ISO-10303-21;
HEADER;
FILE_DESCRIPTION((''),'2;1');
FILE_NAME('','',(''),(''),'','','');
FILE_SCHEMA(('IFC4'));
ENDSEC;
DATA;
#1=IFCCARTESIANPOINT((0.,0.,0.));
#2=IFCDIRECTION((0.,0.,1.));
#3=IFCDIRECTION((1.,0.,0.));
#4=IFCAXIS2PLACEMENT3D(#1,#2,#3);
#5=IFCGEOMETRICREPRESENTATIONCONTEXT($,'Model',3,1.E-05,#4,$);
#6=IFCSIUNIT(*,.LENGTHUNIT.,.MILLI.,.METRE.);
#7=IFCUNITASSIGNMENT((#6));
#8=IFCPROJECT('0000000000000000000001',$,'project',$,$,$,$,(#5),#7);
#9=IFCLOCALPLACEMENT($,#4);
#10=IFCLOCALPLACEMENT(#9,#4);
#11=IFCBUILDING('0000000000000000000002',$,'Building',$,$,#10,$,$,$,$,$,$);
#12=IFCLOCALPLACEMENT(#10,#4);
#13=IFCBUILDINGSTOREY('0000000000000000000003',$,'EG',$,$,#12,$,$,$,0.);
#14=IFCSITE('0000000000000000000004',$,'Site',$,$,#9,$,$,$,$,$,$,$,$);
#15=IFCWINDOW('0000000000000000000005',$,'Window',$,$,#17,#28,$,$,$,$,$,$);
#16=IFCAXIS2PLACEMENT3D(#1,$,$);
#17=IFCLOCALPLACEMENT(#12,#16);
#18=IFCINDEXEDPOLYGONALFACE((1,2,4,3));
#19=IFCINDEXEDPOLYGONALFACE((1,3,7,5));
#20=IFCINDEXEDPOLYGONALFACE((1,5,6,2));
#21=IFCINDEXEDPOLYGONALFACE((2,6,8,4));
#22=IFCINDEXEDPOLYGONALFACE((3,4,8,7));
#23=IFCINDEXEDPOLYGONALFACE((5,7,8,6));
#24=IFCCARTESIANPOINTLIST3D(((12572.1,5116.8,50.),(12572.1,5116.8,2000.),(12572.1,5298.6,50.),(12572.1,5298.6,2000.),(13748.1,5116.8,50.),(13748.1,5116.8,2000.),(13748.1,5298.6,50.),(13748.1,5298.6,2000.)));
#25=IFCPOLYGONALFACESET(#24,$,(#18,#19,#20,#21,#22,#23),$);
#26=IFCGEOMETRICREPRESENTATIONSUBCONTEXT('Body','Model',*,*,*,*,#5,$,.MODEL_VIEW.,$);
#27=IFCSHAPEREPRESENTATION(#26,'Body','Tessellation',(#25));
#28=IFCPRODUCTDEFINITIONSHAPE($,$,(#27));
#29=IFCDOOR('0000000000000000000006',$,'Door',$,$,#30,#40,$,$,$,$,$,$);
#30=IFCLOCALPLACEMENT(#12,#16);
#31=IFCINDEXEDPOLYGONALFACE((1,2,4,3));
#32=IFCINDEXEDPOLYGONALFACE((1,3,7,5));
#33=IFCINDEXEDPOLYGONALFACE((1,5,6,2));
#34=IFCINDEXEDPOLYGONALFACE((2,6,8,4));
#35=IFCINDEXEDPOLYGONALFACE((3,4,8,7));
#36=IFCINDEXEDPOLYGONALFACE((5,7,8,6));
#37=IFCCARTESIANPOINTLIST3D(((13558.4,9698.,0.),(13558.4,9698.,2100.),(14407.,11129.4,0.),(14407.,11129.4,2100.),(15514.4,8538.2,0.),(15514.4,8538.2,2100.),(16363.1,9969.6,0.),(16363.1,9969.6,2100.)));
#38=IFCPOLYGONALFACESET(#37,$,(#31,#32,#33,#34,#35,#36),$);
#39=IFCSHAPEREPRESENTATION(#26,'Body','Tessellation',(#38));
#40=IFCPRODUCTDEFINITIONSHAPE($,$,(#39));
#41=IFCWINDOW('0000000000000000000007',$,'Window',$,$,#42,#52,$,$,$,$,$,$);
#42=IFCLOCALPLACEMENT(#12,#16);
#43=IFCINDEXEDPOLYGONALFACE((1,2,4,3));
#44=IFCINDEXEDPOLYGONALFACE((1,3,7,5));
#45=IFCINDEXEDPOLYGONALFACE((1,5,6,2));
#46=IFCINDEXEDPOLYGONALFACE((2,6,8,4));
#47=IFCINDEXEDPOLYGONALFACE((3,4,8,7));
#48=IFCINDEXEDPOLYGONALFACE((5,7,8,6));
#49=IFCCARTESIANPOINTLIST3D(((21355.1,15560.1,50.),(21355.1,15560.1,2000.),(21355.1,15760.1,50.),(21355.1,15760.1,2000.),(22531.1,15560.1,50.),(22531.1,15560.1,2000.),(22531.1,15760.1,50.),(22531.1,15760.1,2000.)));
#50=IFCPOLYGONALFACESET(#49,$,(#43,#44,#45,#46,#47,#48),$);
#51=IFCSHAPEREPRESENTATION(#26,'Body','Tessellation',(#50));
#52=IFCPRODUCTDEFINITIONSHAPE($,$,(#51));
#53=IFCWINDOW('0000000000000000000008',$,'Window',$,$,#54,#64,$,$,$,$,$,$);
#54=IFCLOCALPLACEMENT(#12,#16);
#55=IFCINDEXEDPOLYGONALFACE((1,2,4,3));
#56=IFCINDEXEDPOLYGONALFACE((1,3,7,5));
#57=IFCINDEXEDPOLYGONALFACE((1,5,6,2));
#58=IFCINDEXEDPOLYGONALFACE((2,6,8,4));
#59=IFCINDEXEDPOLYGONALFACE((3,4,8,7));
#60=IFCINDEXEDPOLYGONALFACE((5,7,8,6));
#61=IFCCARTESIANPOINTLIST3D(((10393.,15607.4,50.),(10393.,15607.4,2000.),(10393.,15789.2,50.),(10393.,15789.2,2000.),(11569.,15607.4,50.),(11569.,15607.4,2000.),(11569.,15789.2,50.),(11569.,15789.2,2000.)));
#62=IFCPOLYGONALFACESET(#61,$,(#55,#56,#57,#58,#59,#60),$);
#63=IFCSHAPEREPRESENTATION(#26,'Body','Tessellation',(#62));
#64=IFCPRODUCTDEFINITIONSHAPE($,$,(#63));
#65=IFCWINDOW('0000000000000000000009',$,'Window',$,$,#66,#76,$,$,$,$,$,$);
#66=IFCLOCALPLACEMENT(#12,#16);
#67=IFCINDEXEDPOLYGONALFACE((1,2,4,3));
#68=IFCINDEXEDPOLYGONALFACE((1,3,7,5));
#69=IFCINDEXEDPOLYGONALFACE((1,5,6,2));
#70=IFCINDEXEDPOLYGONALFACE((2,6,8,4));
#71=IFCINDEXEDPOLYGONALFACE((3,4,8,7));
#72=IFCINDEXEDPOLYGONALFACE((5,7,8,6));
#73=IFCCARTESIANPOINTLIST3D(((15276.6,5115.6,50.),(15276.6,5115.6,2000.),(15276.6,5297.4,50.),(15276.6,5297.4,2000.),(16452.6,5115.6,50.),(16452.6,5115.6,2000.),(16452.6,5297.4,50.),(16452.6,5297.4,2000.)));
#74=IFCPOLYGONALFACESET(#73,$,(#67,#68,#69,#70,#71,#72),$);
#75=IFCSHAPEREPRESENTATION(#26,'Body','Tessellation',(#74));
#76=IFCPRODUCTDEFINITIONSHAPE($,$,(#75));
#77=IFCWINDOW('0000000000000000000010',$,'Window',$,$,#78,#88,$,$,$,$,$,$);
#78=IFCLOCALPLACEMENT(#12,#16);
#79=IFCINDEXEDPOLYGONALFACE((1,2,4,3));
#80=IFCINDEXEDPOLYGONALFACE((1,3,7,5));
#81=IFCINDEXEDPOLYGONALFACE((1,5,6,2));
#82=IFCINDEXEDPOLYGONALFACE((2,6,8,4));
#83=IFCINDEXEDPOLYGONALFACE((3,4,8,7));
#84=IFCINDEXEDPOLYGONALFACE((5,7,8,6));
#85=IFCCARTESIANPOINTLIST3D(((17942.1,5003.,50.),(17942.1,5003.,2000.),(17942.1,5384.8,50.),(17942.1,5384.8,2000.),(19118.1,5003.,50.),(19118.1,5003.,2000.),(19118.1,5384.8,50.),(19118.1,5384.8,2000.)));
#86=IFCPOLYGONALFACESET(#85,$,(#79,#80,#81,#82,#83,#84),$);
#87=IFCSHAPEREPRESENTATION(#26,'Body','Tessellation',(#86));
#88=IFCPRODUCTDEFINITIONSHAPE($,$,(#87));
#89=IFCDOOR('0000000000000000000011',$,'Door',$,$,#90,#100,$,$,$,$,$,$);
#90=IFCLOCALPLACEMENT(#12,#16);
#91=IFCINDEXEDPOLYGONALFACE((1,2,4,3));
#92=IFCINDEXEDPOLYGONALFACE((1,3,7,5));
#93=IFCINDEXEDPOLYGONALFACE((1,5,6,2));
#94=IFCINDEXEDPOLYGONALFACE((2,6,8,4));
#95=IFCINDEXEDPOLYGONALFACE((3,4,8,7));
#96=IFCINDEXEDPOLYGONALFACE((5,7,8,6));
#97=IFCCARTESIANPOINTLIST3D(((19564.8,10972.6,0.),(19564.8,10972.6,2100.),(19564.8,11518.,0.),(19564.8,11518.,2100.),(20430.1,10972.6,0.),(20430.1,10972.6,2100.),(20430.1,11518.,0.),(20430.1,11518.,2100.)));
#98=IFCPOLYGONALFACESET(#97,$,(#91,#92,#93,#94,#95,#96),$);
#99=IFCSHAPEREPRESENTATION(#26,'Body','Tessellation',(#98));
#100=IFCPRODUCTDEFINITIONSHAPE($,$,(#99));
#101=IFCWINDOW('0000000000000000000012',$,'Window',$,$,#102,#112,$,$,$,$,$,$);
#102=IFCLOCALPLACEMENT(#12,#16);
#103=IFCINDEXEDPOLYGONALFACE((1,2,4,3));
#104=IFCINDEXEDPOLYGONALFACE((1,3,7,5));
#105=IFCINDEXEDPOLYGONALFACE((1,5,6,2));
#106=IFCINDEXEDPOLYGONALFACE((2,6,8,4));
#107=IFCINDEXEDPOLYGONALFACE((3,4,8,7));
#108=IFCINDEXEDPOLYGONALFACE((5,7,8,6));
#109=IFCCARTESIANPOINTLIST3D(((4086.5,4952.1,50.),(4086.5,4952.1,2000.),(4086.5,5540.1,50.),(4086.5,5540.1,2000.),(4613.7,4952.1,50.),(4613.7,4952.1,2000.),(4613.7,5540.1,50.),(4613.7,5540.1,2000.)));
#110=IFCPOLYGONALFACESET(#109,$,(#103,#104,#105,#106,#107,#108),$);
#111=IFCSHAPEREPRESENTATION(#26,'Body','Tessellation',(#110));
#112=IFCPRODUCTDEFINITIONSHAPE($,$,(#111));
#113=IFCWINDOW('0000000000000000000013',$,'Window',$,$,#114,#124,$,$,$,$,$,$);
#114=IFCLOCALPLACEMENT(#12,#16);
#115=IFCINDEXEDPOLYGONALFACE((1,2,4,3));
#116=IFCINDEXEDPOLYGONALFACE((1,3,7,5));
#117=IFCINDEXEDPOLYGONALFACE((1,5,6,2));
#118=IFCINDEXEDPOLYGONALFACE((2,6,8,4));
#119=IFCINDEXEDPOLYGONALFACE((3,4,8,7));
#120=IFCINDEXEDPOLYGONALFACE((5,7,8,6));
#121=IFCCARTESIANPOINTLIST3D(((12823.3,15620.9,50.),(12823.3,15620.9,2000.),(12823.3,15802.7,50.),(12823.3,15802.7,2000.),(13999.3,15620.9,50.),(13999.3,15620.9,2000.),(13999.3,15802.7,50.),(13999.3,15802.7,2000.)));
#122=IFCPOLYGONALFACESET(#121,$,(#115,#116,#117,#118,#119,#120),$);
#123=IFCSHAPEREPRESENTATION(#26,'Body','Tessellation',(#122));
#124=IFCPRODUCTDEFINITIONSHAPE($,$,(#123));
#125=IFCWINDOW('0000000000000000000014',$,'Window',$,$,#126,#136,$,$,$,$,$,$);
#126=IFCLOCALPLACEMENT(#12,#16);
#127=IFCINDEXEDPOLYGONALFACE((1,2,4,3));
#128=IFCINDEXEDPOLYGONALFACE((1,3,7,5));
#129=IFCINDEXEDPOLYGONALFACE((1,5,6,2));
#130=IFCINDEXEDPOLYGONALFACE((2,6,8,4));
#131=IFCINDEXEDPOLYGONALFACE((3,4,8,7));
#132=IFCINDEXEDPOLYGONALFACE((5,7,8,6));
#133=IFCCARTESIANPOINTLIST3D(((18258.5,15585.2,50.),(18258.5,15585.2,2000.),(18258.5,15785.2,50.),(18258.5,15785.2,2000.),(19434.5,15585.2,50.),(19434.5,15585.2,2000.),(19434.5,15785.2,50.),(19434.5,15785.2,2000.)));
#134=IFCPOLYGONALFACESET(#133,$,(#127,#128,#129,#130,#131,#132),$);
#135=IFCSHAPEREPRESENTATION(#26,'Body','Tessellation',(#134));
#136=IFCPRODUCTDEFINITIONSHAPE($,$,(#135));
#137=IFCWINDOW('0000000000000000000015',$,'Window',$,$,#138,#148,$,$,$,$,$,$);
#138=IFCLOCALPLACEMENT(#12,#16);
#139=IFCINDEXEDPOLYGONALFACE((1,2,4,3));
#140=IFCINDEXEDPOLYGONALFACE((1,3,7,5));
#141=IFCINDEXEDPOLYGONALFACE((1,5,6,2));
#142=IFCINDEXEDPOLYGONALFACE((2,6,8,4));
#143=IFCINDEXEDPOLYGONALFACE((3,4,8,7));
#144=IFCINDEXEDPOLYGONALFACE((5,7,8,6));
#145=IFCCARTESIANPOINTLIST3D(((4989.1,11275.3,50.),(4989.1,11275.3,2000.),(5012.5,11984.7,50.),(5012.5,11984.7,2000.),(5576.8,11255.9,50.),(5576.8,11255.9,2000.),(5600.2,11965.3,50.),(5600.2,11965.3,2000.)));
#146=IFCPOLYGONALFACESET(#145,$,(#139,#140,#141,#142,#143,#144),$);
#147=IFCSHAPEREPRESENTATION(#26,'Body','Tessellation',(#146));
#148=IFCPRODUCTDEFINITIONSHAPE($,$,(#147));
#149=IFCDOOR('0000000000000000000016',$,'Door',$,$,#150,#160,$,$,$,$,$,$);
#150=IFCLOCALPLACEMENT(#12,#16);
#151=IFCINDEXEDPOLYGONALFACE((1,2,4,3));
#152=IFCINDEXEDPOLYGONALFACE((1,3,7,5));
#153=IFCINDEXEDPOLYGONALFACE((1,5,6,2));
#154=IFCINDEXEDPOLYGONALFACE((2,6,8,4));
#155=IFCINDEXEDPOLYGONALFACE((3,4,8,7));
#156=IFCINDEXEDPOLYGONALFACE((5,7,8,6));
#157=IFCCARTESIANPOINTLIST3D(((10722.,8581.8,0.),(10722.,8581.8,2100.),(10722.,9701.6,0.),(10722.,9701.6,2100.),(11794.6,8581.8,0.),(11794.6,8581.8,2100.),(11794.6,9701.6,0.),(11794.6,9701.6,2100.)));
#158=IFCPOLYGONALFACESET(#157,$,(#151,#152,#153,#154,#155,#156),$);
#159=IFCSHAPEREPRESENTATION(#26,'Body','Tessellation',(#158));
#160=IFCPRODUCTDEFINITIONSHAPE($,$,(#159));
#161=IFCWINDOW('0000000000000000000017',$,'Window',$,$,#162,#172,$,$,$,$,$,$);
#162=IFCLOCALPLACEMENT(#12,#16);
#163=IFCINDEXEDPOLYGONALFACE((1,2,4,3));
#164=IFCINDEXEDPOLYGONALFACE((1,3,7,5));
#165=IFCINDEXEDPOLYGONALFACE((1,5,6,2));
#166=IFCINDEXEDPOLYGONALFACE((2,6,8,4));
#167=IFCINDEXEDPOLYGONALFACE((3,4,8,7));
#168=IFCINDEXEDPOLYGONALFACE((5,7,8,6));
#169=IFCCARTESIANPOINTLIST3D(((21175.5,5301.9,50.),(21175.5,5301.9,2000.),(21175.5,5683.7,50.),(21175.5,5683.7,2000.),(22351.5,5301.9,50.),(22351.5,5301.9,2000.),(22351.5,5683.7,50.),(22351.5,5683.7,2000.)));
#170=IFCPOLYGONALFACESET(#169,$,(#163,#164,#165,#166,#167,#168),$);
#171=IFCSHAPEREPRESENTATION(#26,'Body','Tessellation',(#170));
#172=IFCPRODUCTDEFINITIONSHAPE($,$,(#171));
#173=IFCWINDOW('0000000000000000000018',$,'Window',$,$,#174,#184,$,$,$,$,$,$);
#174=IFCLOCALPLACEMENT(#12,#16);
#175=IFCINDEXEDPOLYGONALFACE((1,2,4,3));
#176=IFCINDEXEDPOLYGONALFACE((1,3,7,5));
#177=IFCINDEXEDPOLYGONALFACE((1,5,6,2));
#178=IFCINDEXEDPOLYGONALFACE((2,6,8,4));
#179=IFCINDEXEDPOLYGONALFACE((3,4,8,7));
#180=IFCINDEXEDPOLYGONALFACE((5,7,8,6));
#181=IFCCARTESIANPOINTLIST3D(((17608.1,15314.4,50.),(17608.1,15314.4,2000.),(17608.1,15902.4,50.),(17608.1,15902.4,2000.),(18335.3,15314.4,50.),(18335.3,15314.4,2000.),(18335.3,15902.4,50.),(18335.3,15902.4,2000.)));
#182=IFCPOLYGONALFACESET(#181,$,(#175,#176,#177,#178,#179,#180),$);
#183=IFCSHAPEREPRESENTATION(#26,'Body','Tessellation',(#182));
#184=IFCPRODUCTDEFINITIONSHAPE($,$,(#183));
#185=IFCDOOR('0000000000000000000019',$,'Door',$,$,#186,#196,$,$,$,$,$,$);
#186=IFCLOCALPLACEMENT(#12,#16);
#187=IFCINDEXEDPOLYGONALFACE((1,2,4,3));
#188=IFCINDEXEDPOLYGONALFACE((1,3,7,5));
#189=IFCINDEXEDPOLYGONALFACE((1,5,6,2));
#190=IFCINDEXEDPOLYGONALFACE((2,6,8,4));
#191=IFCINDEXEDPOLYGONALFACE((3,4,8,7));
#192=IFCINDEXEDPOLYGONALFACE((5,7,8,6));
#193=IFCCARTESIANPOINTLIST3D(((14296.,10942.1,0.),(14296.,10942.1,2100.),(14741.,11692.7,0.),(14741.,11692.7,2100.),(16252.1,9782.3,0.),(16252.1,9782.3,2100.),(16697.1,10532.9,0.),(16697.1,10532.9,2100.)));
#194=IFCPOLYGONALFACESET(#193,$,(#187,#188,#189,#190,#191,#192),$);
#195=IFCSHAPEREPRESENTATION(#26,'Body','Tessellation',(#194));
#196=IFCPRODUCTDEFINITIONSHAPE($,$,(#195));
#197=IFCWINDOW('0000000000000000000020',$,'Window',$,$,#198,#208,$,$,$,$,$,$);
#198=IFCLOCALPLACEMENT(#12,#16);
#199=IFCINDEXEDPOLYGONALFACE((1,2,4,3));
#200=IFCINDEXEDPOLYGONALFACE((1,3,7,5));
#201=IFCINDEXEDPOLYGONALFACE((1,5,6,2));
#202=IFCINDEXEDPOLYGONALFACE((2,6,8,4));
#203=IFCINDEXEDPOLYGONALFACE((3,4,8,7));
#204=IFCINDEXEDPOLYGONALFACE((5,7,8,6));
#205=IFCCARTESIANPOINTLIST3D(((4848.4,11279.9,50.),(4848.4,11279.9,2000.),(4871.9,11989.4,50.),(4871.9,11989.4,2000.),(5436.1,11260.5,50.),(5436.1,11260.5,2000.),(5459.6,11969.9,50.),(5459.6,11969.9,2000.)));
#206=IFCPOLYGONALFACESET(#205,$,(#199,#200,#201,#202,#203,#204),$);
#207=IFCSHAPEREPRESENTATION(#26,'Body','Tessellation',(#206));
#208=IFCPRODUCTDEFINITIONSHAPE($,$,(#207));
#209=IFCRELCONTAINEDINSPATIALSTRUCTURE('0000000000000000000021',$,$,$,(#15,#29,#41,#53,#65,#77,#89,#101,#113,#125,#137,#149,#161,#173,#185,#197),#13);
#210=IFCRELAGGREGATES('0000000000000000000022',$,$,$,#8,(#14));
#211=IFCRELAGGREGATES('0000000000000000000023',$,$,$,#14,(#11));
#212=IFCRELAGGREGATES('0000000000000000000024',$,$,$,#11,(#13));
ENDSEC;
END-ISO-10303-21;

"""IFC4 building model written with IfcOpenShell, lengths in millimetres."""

from ifc_helpers import new_model, si_unit, frame, origin_with_axes, place, context, subcontext, project, spatial, rectangle, extrude, element, save


model = new_model("IFC4")

# Units and contexts
model_context = context("Model", 3, precision=1e-05, world=origin_with_axes())
body_context = subcontext(model_context, "Body", "Model", "MODEL_VIEW")
ifc_project = project(units=[si_unit("LENGTHUNIT", "METRE", prefix="MILLI")], contexts=[model_context])

# Site, building, storey
site_placement = place(None, origin_with_axes())
site = spatial("IfcSite", under=ifc_project, at=site_placement, Name="Site")
building_placement = place(site_placement, origin_with_axes())
building = spatial("IfcBuilding", under=site, at=building_placement, Name="Building")
storey_placement = place(building_placement, origin_with_axes())
storey = spatial("IfcBuildingStorey", under=building, at=storey_placement, Name="EG", Elevation=0.0)

# Window
window_1_placement = place(storey_placement, origin_with_axes())
element("IfcWindow", 1, at=window_1_placement, inside=storey, Name="Window", context=body_context, shape_type="SweptSolid", body=[
    extrude(rectangle(XDim=1176.0, YDim=181.8), frame((13160.1, 5207.7, 50.0), z_axis=(0.0, 0.0, 1.0), x_axis=(1.0, 0.0, 0.0)), (0.0, 0.0, 1.0), 1950.0),
])

# Door
door_1_placement = place(storey_placement, origin_with_axes())
element("IfcDoor", 2, at=door_1_placement, inside=storey, Name="Door", context=body_context, shape_type="SweptSolid", body=[
    extrude(rectangle(XDim=1664.0, YDim=2274.1), frame((14960.7, 9833.8, 0.0), z_axis=(0.0, 0.0, 1.0), x_axis=(-0.510011, -0.860168, 0.0)), (0.0, 0.0, 1.0), 2100.0),
])

# Windows
window_2_placement = place(storey_placement, origin_with_axes())
element("IfcWindow", 3, at=window_2_placement, inside=storey, Name="Window", context=body_context, shape_type="SweptSolid", body=[
    extrude(rectangle(XDim=1176.0, YDim=200.0), frame((21943.1, 15660.1, 50.0), z_axis=(0.0, 0.0, 1.0), x_axis=(1.0, 0.0, 0.0)), (0.0, 0.0, 1.0), 1950.0),
])
window_3_placement = place(storey_placement, origin_with_axes())
element("IfcWindow", 4, at=window_3_placement, inside=storey, Name="Window", context=body_context, shape_type="SweptSolid", body=[
    extrude(rectangle(XDim=1176.0, YDim=181.8), frame((10981.0, 15698.3, 50.0), z_axis=(0.0, 0.0, 1.0), x_axis=(1.0, 0.0, 0.0)), (0.0, 0.0, 1.0), 1950.0),
])
window_4_placement = place(storey_placement, origin_with_axes())
element("IfcWindow", 5, at=window_4_placement, inside=storey, Name="Window", context=body_context, shape_type="SweptSolid", body=[
    extrude(rectangle(XDim=1176.0, YDim=181.8), frame((15864.6, 5206.5, 50.0), z_axis=(0.0, 0.0, 1.0), x_axis=(1.0, 0.0, 0.0)), (0.0, 0.0, 1.0), 1950.0),
])
window_5_placement = place(storey_placement, origin_with_axes())
element("IfcWindow", 6, at=window_5_placement, inside=storey, Name="Window", context=body_context, shape_type="SweptSolid", body=[
    extrude(rectangle(XDim=1176.0, YDim=381.8), frame((18530.1, 5193.9, 50.0), z_axis=(0.0, 0.0, 1.0), x_axis=(1.0, 0.0, 0.0)), (0.0, 0.0, 1.0), 1950.0),
])

# Door
door_2_placement = place(storey_placement, origin_with_axes())
element("IfcDoor", 7, at=door_2_placement, inside=storey, Name="Door", context=body_context, shape_type="SweptSolid", body=[
    extrude(rectangle(XDim=865.3, YDim=545.4), frame((19997.4, 11245.3, 0.0), z_axis=(0.0, 0.0, 1.0), x_axis=(1.0, 0.0, 0.0)), (0.0, 0.0, 1.0), 2100.0),
])

# Windows
window_6_placement = place(storey_placement, origin_with_axes())
element("IfcWindow", 8, at=window_6_placement, inside=storey, Name="Window", context=body_context, shape_type="SweptSolid", body=[
    extrude(rectangle(XDim=588.0, YDim=527.2), frame((4350.1, 5246.1, 50.0), z_axis=(0.0, 0.0, 1.0), x_axis=(0.0, 1.0, 0.0)), (0.0, 0.0, 1.0), 1950.0),
])
window_7_placement = place(storey_placement, origin_with_axes())
element("IfcWindow", 9, at=window_7_placement, inside=storey, Name="Window", context=body_context, shape_type="SweptSolid", body=[
    extrude(rectangle(XDim=1176.0, YDim=181.8), frame((13411.3, 15711.8, 50.0), z_axis=(0.0, 0.0, 1.0), x_axis=(1.0, 0.0, 0.0)), (0.0, 0.0, 1.0), 1950.0),
])
window_8_placement = place(storey_placement, origin_with_axes())
element("IfcWindow", 10, at=window_8_placement, inside=storey, Name="Window", context=body_context, shape_type="SweptSolid", body=[
    extrude(rectangle(XDim=1176.0, YDim=200.0), frame((18846.5, 15685.2, 50.0), z_axis=(0.0, 0.0, 1.0), x_axis=(1.0, 0.0, 0.0)), (0.0, 0.0, 1.0), 1950.0),
])
window_9_placement = place(storey_placement, origin_with_axes())
element("IfcWindow", 11, at=window_9_placement, inside=storey, Name="Window", context=body_context, shape_type="SweptSolid", body=[
    extrude(rectangle(XDim=588.0, YDim=709.8), frame((5294.6, 11620.3, 50.0), z_axis=(0.0, 0.0, 1.0), x_axis=(0.999454, -0.03304, 0.0)), (0.0, 0.0, 1.0), 1950.0),
])

# Door
door_3_placement = place(storey_placement, origin_with_axes())
element("IfcDoor", 12, at=door_3_placement, inside=storey, Name="Door", context=body_context, shape_type="SweptSolid", body=[
    extrude(rectangle(XDim=1119.9, YDim=1072.6), frame((11258.3, 9141.7, 0.0), z_axis=(0.0, 0.0, 1.0), x_axis=(0.0, 1.0, 0.0)), (0.0, 0.0, 1.0), 2100.0),
])

# Windows
window_10_placement = place(storey_placement, origin_with_axes())
element("IfcWindow", 13, at=window_10_placement, inside=storey, Name="Window", context=body_context, shape_type="SweptSolid", body=[
    extrude(rectangle(XDim=1176.0, YDim=381.8), frame((21763.5, 5492.8, 50.0), z_axis=(0.0, 0.0, 1.0), x_axis=(1.0, 0.0, 0.0)), (0.0, 0.0, 1.0), 1950.0),
])
window_11_placement = place(storey_placement, origin_with_axes())
element("IfcWindow", 14, at=window_11_placement, inside=storey, Name="Window", context=body_context, shape_type="SweptSolid", body=[
    extrude(rectangle(XDim=588.0, YDim=727.2), frame((17971.7, 15608.4, 50.0), z_axis=(0.0, 0.0, 1.0), x_axis=(0.0, 1.0, 0.0)), (0.0, 0.0, 1.0), 1950.0),
])

# Door
door_4_placement = place(storey_placement, origin_with_axes())
element("IfcDoor", 15, at=door_4_placement, inside=storey, Name="Door", context=body_context, shape_type="SweptSolid", body=[
    extrude(rectangle(XDim=872.6, YDim=2274.1), frame((15496.6, 10737.5, 0.0), z_axis=(0.0, 0.0, 1.0), x_axis=(-0.510011, -0.860168, 0.0)), (0.0, 0.0, 1.0), 2100.0),
])

# Window
window_12_placement = place(storey_placement, origin_with_axes())
element("IfcWindow", 16, at=window_12_placement, inside=storey, Name="Window", context=body_context, shape_type="SweptSolid", body=[
    extrude(rectangle(XDim=588.0, YDim=709.8), frame((5154.0, 11624.9, 50.0), z_axis=(0.0, 0.0, 1.0), x_axis=(0.999454, -0.03304, 0.0)), (0.0, 0.0, 1.0), 1950.0),
])

save(model, "model.ifc")
